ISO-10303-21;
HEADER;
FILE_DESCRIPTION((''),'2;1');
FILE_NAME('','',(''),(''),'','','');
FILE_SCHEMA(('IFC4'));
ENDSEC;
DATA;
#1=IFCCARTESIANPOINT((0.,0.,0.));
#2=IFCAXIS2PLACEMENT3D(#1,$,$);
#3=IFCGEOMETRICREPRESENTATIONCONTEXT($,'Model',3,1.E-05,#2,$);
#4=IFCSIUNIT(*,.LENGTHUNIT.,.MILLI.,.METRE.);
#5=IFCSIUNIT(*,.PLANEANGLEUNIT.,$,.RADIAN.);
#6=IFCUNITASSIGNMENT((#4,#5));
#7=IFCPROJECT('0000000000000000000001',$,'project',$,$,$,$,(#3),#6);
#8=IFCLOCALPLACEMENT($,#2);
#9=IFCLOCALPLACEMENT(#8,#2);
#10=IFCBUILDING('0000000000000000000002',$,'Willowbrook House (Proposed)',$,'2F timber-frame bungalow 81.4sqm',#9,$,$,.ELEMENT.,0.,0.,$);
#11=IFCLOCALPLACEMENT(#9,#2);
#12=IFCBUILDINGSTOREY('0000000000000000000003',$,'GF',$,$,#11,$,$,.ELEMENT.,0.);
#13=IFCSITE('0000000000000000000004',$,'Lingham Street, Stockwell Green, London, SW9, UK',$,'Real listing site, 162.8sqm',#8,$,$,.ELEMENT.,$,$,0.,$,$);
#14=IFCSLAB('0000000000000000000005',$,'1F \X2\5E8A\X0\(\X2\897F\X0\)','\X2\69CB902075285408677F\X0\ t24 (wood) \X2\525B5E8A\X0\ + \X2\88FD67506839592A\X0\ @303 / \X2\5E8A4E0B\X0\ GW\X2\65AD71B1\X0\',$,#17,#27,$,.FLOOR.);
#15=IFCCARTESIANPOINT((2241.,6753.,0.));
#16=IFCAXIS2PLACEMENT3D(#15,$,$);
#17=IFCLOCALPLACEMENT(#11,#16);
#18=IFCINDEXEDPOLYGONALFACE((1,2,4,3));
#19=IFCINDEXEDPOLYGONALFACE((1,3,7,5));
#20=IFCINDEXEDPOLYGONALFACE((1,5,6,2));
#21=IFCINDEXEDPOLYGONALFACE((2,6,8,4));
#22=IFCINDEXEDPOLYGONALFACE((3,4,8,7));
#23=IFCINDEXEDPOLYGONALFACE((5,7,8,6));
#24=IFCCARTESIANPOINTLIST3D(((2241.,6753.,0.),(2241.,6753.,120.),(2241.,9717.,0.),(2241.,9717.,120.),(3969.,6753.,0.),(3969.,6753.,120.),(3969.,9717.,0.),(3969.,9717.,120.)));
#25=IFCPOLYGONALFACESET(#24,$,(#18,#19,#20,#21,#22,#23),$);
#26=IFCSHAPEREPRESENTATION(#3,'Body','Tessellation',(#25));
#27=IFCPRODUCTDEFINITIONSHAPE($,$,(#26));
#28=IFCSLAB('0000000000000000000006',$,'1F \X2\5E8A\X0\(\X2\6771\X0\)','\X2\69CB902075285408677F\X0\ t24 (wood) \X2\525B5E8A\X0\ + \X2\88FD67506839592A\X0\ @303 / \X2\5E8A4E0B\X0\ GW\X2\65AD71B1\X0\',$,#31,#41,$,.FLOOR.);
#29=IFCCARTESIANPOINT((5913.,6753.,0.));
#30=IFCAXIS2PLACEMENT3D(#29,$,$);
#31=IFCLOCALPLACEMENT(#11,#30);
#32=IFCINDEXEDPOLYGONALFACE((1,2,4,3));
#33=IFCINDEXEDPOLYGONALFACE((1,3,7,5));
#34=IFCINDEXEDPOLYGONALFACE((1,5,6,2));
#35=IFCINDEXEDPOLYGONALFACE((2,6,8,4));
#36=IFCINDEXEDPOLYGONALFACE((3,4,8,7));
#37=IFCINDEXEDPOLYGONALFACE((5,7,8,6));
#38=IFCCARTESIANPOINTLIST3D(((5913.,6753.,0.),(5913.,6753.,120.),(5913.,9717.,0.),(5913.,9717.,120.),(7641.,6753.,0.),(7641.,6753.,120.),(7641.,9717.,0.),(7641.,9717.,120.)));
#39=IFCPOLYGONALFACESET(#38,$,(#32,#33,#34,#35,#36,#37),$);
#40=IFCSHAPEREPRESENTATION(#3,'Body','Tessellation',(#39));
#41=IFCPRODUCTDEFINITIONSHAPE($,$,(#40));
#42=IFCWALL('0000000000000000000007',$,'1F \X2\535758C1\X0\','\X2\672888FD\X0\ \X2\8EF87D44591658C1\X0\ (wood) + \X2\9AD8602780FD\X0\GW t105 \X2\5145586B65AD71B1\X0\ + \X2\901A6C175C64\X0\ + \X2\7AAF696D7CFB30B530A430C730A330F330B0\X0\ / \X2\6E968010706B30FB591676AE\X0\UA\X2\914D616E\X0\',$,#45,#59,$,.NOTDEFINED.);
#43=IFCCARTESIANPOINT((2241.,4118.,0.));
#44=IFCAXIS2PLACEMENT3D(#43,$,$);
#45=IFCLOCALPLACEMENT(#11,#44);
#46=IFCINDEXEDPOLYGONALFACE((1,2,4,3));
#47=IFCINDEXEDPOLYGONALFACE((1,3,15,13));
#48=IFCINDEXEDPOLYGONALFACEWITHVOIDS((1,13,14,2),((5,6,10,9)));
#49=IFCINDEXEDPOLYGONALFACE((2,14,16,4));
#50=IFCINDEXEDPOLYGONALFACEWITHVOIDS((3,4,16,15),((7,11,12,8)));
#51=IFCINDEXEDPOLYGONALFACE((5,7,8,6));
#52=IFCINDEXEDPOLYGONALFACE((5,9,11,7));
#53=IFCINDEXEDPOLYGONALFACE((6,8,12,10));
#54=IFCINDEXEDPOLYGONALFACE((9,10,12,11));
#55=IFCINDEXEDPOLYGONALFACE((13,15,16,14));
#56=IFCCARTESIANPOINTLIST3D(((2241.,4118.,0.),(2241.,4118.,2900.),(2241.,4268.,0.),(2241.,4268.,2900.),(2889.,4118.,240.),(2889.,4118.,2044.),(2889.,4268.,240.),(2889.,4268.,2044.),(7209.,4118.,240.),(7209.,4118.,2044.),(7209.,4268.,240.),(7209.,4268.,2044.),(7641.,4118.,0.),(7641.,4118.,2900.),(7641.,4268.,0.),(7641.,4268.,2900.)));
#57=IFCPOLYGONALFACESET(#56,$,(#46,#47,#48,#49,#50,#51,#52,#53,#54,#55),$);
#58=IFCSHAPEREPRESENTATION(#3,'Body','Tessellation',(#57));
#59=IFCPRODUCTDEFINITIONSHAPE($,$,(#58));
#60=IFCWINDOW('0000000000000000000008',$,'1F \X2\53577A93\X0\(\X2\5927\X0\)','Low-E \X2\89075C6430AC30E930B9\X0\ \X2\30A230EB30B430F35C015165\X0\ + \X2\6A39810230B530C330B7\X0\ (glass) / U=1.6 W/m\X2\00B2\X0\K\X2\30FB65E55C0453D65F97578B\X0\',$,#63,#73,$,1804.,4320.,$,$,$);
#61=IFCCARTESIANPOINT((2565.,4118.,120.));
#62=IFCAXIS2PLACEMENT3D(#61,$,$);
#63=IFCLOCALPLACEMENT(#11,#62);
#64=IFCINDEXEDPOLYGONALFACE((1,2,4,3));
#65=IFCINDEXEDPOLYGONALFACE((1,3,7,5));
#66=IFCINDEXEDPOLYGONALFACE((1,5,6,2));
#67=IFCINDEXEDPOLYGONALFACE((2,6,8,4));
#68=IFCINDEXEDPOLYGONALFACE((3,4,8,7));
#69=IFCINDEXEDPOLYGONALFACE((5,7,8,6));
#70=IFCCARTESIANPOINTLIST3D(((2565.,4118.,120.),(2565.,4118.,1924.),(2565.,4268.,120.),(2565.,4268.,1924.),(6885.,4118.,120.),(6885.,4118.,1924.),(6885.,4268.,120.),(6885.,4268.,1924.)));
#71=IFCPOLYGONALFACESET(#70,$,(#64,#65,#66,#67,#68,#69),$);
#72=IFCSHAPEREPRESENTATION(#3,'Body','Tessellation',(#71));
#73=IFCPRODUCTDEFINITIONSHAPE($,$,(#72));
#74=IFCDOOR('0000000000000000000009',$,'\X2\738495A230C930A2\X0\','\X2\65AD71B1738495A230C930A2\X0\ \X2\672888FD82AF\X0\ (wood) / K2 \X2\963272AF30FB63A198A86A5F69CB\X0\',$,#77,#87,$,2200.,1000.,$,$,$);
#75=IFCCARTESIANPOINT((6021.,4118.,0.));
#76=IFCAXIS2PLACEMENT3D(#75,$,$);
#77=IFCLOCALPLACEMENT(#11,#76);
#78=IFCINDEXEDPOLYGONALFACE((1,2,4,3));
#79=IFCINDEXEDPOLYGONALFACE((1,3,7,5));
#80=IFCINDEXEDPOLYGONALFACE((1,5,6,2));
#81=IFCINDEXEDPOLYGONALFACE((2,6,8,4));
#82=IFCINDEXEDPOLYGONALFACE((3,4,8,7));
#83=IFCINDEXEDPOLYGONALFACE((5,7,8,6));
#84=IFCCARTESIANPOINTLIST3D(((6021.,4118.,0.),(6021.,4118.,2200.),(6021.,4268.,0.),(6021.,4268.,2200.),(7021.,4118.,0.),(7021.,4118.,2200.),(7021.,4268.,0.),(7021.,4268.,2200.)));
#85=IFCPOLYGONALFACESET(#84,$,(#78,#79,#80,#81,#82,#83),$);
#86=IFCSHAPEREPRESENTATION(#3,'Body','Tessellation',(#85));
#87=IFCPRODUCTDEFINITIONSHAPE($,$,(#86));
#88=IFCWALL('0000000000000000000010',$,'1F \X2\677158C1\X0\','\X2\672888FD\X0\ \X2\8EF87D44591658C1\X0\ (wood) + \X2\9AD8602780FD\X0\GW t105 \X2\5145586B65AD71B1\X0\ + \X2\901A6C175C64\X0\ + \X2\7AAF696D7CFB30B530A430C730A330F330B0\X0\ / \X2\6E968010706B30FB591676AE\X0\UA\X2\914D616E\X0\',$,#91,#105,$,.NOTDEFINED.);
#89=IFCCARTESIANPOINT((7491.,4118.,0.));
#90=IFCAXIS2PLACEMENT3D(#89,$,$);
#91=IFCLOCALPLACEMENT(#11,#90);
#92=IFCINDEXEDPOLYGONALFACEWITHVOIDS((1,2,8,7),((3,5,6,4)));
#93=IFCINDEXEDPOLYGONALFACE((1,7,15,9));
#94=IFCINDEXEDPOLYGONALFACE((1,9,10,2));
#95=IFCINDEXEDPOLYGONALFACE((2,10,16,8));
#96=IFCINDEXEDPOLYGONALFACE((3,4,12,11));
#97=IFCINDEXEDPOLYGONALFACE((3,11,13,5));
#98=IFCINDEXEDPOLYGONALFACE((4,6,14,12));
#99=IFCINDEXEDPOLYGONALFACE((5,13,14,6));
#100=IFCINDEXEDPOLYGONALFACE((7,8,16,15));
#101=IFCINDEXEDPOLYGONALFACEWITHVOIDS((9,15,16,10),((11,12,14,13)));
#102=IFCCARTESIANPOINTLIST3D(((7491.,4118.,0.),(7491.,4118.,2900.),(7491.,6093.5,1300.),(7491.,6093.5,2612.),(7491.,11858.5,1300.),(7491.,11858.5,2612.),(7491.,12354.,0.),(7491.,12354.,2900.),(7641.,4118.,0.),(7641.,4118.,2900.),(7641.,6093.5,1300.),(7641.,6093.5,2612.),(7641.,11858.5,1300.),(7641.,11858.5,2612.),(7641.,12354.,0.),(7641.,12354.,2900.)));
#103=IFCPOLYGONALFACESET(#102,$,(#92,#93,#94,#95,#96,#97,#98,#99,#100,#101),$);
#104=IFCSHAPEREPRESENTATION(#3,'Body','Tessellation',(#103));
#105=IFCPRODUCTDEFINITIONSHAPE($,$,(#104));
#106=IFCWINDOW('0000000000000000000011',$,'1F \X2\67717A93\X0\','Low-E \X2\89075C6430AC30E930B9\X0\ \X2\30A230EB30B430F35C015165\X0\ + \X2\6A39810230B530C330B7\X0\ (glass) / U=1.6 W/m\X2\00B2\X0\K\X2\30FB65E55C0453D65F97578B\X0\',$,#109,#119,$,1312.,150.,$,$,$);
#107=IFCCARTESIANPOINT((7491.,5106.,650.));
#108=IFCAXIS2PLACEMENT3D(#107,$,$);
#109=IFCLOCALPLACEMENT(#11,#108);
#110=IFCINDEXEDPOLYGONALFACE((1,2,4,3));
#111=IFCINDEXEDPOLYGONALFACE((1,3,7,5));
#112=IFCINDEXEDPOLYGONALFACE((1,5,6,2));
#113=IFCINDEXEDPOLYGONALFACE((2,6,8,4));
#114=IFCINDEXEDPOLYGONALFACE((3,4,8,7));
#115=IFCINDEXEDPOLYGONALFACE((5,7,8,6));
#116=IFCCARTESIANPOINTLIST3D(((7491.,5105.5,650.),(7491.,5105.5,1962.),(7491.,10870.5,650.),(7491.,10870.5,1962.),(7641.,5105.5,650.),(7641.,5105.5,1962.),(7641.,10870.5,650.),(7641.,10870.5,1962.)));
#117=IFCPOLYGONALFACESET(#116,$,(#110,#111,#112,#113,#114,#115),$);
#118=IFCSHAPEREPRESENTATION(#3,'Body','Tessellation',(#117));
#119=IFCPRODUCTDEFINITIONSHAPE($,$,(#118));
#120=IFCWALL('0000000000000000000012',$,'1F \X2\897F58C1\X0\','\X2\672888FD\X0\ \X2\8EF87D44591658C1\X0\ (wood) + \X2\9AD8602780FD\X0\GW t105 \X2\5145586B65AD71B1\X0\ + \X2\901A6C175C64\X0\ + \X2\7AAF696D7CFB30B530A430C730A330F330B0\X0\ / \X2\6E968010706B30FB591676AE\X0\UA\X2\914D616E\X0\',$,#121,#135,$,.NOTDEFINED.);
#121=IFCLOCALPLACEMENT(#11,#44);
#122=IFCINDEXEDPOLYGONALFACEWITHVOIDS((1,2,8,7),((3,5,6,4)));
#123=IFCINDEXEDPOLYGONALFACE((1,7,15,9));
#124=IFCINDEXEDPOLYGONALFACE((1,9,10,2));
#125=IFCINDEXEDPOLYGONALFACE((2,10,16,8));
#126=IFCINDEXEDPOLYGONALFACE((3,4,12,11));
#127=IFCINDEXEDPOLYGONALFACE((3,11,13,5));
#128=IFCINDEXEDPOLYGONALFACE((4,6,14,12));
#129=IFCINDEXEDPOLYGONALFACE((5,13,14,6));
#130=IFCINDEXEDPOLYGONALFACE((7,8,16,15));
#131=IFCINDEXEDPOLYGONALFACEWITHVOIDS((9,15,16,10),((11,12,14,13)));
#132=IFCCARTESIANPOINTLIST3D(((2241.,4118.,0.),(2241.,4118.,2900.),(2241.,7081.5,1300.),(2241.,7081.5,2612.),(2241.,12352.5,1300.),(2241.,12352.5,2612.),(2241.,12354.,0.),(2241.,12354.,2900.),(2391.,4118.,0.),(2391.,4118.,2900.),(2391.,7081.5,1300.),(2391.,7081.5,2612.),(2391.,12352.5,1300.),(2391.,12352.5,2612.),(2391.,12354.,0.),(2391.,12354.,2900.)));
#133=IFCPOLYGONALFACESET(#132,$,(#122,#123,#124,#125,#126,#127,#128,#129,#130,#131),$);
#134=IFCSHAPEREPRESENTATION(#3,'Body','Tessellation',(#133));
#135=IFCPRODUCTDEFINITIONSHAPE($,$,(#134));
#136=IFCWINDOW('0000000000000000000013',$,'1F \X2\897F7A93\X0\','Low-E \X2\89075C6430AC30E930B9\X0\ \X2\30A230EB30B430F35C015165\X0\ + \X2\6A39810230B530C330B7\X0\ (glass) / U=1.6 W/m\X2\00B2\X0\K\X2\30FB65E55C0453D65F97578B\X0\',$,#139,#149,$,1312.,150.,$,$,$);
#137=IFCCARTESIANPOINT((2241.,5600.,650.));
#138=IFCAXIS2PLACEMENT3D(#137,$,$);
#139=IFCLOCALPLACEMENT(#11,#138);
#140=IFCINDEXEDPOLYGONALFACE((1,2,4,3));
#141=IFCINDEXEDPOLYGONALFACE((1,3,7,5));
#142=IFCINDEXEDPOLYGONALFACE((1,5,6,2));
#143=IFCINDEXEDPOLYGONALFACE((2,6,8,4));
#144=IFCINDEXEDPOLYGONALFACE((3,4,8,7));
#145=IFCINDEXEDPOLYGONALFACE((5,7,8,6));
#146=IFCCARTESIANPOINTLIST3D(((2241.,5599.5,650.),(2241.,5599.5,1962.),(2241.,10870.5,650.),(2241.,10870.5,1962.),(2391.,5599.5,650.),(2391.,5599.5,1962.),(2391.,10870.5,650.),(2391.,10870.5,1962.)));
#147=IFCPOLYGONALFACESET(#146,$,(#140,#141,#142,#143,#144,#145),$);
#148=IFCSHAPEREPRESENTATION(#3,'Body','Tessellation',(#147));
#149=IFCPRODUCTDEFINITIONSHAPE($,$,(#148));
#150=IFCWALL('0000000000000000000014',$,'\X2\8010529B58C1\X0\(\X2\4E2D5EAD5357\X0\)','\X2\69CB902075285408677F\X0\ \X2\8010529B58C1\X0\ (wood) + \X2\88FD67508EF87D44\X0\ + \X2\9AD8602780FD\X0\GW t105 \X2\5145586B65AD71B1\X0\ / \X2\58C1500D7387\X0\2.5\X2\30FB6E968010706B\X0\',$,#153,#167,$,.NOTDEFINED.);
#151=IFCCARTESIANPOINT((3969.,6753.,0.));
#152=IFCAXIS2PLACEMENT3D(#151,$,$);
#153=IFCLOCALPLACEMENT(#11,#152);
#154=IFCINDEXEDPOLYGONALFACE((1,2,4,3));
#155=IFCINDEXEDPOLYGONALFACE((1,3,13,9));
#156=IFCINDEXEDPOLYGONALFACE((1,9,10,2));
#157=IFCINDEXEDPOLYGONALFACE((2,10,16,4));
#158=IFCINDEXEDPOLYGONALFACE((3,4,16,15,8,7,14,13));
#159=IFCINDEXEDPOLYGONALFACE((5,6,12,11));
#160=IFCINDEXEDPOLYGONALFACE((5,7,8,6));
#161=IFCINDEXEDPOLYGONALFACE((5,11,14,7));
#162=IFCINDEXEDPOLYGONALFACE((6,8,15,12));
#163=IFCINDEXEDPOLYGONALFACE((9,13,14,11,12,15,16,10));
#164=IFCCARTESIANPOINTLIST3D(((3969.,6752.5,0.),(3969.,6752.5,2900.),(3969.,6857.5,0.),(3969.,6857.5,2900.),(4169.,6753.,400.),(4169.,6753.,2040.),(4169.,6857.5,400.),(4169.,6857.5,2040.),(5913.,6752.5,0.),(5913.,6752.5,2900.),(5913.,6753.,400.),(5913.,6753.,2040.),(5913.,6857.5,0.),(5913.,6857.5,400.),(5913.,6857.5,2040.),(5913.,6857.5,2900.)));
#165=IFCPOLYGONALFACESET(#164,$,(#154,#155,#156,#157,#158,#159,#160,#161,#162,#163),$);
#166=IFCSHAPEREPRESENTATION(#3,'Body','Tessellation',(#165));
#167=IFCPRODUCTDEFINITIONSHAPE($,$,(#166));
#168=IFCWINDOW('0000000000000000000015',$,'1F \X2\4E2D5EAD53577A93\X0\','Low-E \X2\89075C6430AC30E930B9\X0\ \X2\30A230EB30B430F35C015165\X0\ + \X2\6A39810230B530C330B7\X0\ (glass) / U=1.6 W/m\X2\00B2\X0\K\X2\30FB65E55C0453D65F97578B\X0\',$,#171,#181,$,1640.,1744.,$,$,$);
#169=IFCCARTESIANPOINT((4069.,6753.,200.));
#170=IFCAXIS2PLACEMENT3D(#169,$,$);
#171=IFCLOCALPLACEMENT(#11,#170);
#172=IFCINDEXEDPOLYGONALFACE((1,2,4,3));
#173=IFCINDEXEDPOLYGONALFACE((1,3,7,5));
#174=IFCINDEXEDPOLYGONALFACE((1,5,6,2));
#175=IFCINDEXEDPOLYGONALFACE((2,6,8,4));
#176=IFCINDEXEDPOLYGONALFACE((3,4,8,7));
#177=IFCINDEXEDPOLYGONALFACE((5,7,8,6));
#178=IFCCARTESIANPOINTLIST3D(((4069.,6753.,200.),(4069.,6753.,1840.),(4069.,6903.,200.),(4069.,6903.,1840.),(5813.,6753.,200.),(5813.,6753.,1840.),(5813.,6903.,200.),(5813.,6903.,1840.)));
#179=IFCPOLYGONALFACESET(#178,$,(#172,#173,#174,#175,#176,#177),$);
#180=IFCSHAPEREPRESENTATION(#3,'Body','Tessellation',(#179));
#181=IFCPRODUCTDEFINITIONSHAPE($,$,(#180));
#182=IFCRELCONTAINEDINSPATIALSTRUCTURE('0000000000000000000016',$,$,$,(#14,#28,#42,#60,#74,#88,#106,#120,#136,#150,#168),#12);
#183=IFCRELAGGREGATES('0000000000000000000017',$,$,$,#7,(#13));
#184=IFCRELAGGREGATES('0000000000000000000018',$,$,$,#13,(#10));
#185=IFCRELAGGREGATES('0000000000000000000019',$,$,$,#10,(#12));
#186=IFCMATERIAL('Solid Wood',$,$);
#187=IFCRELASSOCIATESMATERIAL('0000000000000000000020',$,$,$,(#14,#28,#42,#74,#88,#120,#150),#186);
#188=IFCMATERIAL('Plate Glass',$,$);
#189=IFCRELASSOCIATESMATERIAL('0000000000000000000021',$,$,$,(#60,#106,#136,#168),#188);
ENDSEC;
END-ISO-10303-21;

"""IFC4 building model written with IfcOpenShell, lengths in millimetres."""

from ifc_helpers import new_model, si_unit, frame, frame_2d, origin, place, context, project, spatial, rectangle, extrude, material, element, fill, save


model = new_model("IFC4")

# Units and contexts
model_context = context("Model", 3, precision=1e-05, world=origin())
ifc_project = project(units=[si_unit("LENGTHUNIT", "METRE", prefix="MILLI"), si_unit("PLANEANGLEUNIT", "RADIAN")], contexts=[model_context])

# Site, building, storey
site_placement = place(None, origin())
site = spatial("IfcSite", under=ifc_project, at=site_placement, Name="Lingham Street, Stockwell Green, London, SW9, UK", ObjectType="Real listing site, 162.8sqm", CompositionType="ELEMENT", RefElevation=0.0)
building_placement = place(site_placement, origin())
building = spatial("IfcBuilding", under=site, at=building_placement, Name="Willowbrook House (Proposed)", ObjectType="2F timber-frame bungalow 81.4sqm", CompositionType="ELEMENT", ElevationOfRefHeight=0.0, ElevationOfTerrain=0.0)
storey_placement = place(building_placement, origin())
storey = spatial("IfcBuildingStorey", under=building, at=storey_placement, Name="GF", CompositionType="ELEMENT", Elevation=0.0)

# Slabs
ifc_material_1 = material(Name="Solid Wood")
slab_1_placement = place(storey_placement, frame((2241.0, 6753.0, 0.0)))
element("IfcSlab", 1, at=slab_1_placement, inside=storey, material=ifc_material_1, Name="1F 床(西)", Description="構造用合板 t24 (wood) 剛床 + 製材根太 @303 / 床下 GW断熱", PredefinedType="FLOOR", context=model_context, shape_type="SweptSolid", body=[
    extrude(rectangle(XDim=1728.0, YDim=2964.0, at=frame_2d((864.0, 1482.0))), frame((2241.0, 6753.0, 0.0)), (0.0, 0.0, 1.0), 120.0),
])
slab_2_placement = place(storey_placement, frame((5913.0, 6753.0, 0.0)))
element("IfcSlab", 2, at=slab_2_placement, inside=storey, material=ifc_material_1, Name="1F 床(東)", Description="構造用合板 t24 (wood) 剛床 + 製材根太 @303 / 床下 GW断熱", PredefinedType="FLOOR", context=model_context, shape_type="SweptSolid", body=[
    extrude(rectangle(XDim=1728.0, YDim=2964.0, at=frame_2d((864.0, 1482.0))), frame((5913.0, 6753.0, 0.0)), (0.0, 0.0, 1.0), 120.0),
])

# Wall, openings, window, door
wall_1_placement = place(storey_placement, frame((2241.0, 4118.0, 0.0)))
wall_1 = element("IfcWall", 3, at=wall_1_placement, inside=storey, material=ifc_material_1, Name="1F 南壁", Description="木製 軸組外壁 (wood) + 高性能GW t105 充填断熱 + 通気層 + 窯業系サイディング / 準耐火・外皮UA配慮", PredefinedType="NOTDEFINED", context=model_context, shape_type="SweptSolid", body=[
    extrude(rectangle(XDim=5400.0, YDim=150.0, at=frame_2d((2700.0, 75.0))), frame((2241.0, 4118.0, 0.0)), (0.0, 0.0, 1.0), 2900.0),
])
opening_1_placement = place(storey_placement, frame((2565.0, 4118.0, 120.0)))
opening_1 = element("IfcOpeningElement", 4, at=opening_1_placement, cuts=wall_1, PredefinedType="NOTDEFINED", context=model_context, shape_type="SweptSolid", body=[
    extrude(rectangle(XDim=4320.0, YDim=150.0, at=frame_2d((2160.0, 75.0))), frame((2565.0, 4118.0, 120.0)), (0.0, 0.0, 1.0), 1804.0),
])
opening_2_placement = place(storey_placement, frame((6021.0, 4118.0, 0.0)))
opening_2 = element("IfcOpeningElement", 5, at=opening_2_placement, cuts=wall_1, PredefinedType="NOTDEFINED", context=model_context, shape_type="SweptSolid", body=[
    extrude(rectangle(XDim=1000.0, YDim=150.0, at=frame_2d((500.0, 75.0))), frame((6021.0, 4118.0, 0.0)), (0.0, 0.0, 1.0), 2200.0),
])
ifc_material_2 = material(Name="Plate Glass")
window_1_placement = place(storey_placement, frame((2565.0, 4118.0, 120.0)))
window_1 = element("IfcWindow", 6, at=window_1_placement, inside=storey, material=ifc_material_2, Name="1F 南窓(大)", Description="Low-E 複層ガラス アルゴン封入 + 樹脂サッシ (glass) / U=1.6 W/m²K・日射取得型", OverallHeight=1804.0, OverallWidth=4320.0, context=model_context, shape_type="SweptSolid", body=[
    extrude(rectangle(XDim=4320.0, YDim=150.0, at=frame_2d((2160.0, 75.0))), frame((2565.0, 4118.0, 120.0)), (0.0, 0.0, 1.0), 1804.0),
])
fill(opening_1, window_1)
door_placement = place(storey_placement, frame((6021.0, 4118.0, 0.0)))
door = element("IfcDoor", 7, at=door_placement, inside=storey, material=ifc_material_1, Name="玄関ドア", Description="断熱玄関ドア 木製芯 (wood) / K2 防犯・採風機構", OverallHeight=2200.0, OverallWidth=1000.0, context=model_context, shape_type="SweptSolid", body=[
    extrude(rectangle(XDim=1000.0, YDim=150.0, at=frame_2d((500.0, 75.0))), frame((6021.0, 4118.0, 0.0)), (0.0, 0.0, 1.0), 2200.0),
])
fill(opening_2, door)

# Walls, openings, windows
wall_2_placement = place(storey_placement, frame((7491.0, 4118.0, 0.0)))
wall_2 = element("IfcWall", 8, at=wall_2_placement, inside=storey, material=ifc_material_1, Name="1F 東壁", Description="木製 軸組外壁 (wood) + 高性能GW t105 充填断熱 + 通気層 + 窯業系サイディング / 準耐火・外皮UA配慮", PredefinedType="NOTDEFINED", context=model_context, shape_type="SweptSolid", body=[
    extrude(rectangle(XDim=150.0, YDim=8236.0, at=frame_2d((75.0, 4118.0))), frame((7491.0, 4118.0, 0.0)), (0.0, 0.0, 1.0), 2900.0),
])
opening_3_placement = place(storey_placement, frame((7491.0, 5106.0, 650.0)))
opening_3 = element("IfcOpeningElement", 9, at=opening_3_placement, cuts=wall_2, PredefinedType="NOTDEFINED", context=model_context, shape_type="SweptSolid", body=[
    extrude(rectangle(XDim=150.0, YDim=5765.0, at=frame_2d((75.0, 2882.0))), frame((7491.0, 5106.0, 650.0)), (0.0, 0.0, 1.0), 1312.0),
])
window_2_placement = place(storey_placement, frame((7491.0, 5106.0, 650.0)))
window_2 = element("IfcWindow", 10, at=window_2_placement, inside=storey, material=ifc_material_2, Name="1F 東窓", Description="Low-E 複層ガラス アルゴン封入 + 樹脂サッシ (glass) / U=1.6 W/m²K・日射取得型", OverallHeight=1312.0, OverallWidth=150.0, context=model_context, shape_type="SweptSolid", body=[
    extrude(rectangle(XDim=150.0, YDim=5765.0, at=frame_2d((75.0, 2882.0))), frame((7491.0, 5106.0, 650.0)), (0.0, 0.0, 1.0), 1312.0),
])
fill(opening_3, window_2)
wall_3_placement = place(storey_placement, frame((2241.0, 4118.0, 0.0)))
wall_3 = element("IfcWall", 11, at=wall_3_placement, inside=storey, material=ifc_material_1, Name="1F 西壁", Description="木製 軸組外壁 (wood) + 高性能GW t105 充填断熱 + 通気層 + 窯業系サイディング / 準耐火・外皮UA配慮", PredefinedType="NOTDEFINED", context=model_context, shape_type="SweptSolid", body=[
    extrude(rectangle(XDim=150.0, YDim=8236.0, at=frame_2d((75.0, 4118.0))), frame((2241.0, 4118.0, 0.0)), (0.0, 0.0, 1.0), 2900.0),
])
opening_4_placement = place(storey_placement, frame((2241.0, 5600.0, 650.0)))
opening_4 = element("IfcOpeningElement", 12, at=opening_4_placement, cuts=wall_3, PredefinedType="NOTDEFINED", context=model_context, shape_type="SweptSolid", body=[
    extrude(rectangle(XDim=150.0, YDim=5271.0, at=frame_2d((75.0, 2635.0))), frame((2241.0, 5600.0, 650.0)), (0.0, 0.0, 1.0), 1312.0),
])
window_3_placement = place(storey_placement, frame((2241.0, 5600.0, 650.0)))
window_3 = element("IfcWindow", 13, at=window_3_placement, inside=storey, material=ifc_material_2, Name="1F 西窓", Description="Low-E 複層ガラス アルゴン封入 + 樹脂サッシ (glass) / U=1.6 W/m²K・日射取得型", OverallHeight=1312.0, OverallWidth=150.0, context=model_context, shape_type="SweptSolid", body=[
    extrude(rectangle(XDim=150.0, YDim=5271.0, at=frame_2d((75.0, 2635.0))), frame((2241.0, 5600.0, 650.0)), (0.0, 0.0, 1.0), 1312.0),
])
fill(opening_4, window_3)
wall_4_placement = place(storey_placement, frame((3969.0, 6753.0, 0.0)))
wall_4 = element("IfcWall", 14, at=wall_4_placement, inside=storey, material=ifc_material_1, Name="耐力壁(中庭南)", Description="構造用合板 耐力壁 (wood) + 製材軸組 + 高性能GW t105 充填断熱 / 壁倍率2.5・準耐火", PredefinedType="NOTDEFINED", context=model_context, shape_type="SweptSolid", body=[
    extrude(rectangle(XDim=1944.0, YDim=105.0, at=frame_2d((972.0, 52.0))), frame((3969.0, 6753.0, 0.0)), (0.0, 0.0, 1.0), 2900.0),
])
opening_5_placement = place(storey_placement, frame((4069.0, 6753.0, 200.0)))
opening_5 = element("IfcOpeningElement", 15, at=opening_5_placement, cuts=wall_4, PredefinedType="NOTDEFINED", context=model_context, shape_type="SweptSolid", body=[
    extrude(rectangle(XDim=1744.0, YDim=150.0, at=frame_2d((872.0, 75.0))), frame((4069.0, 6753.0, 200.0)), (0.0, 0.0, 1.0), 1640.0),
])
window_4_placement = place(storey_placement, frame((4069.0, 6753.0, 200.0)))
window_4 = element("IfcWindow", 16, at=window_4_placement, inside=storey, material=ifc_material_2, Name="1F 中庭南窓", Description="Low-E 複層ガラス アルゴン封入 + 樹脂サッシ (glass) / U=1.6 W/m²K・日射取得型", OverallHeight=1640.0, OverallWidth=1744.0, context=model_context, shape_type="SweptSolid", body=[
    extrude(rectangle(XDim=1744.0, YDim=150.0, at=frame_2d((872.0, 75.0))), frame((4069.0, 6753.0, 200.0)), (0.0, 0.0, 1.0), 1640.0),
])
fill(opening_5, window_4)

save(model, "model.ifc")
